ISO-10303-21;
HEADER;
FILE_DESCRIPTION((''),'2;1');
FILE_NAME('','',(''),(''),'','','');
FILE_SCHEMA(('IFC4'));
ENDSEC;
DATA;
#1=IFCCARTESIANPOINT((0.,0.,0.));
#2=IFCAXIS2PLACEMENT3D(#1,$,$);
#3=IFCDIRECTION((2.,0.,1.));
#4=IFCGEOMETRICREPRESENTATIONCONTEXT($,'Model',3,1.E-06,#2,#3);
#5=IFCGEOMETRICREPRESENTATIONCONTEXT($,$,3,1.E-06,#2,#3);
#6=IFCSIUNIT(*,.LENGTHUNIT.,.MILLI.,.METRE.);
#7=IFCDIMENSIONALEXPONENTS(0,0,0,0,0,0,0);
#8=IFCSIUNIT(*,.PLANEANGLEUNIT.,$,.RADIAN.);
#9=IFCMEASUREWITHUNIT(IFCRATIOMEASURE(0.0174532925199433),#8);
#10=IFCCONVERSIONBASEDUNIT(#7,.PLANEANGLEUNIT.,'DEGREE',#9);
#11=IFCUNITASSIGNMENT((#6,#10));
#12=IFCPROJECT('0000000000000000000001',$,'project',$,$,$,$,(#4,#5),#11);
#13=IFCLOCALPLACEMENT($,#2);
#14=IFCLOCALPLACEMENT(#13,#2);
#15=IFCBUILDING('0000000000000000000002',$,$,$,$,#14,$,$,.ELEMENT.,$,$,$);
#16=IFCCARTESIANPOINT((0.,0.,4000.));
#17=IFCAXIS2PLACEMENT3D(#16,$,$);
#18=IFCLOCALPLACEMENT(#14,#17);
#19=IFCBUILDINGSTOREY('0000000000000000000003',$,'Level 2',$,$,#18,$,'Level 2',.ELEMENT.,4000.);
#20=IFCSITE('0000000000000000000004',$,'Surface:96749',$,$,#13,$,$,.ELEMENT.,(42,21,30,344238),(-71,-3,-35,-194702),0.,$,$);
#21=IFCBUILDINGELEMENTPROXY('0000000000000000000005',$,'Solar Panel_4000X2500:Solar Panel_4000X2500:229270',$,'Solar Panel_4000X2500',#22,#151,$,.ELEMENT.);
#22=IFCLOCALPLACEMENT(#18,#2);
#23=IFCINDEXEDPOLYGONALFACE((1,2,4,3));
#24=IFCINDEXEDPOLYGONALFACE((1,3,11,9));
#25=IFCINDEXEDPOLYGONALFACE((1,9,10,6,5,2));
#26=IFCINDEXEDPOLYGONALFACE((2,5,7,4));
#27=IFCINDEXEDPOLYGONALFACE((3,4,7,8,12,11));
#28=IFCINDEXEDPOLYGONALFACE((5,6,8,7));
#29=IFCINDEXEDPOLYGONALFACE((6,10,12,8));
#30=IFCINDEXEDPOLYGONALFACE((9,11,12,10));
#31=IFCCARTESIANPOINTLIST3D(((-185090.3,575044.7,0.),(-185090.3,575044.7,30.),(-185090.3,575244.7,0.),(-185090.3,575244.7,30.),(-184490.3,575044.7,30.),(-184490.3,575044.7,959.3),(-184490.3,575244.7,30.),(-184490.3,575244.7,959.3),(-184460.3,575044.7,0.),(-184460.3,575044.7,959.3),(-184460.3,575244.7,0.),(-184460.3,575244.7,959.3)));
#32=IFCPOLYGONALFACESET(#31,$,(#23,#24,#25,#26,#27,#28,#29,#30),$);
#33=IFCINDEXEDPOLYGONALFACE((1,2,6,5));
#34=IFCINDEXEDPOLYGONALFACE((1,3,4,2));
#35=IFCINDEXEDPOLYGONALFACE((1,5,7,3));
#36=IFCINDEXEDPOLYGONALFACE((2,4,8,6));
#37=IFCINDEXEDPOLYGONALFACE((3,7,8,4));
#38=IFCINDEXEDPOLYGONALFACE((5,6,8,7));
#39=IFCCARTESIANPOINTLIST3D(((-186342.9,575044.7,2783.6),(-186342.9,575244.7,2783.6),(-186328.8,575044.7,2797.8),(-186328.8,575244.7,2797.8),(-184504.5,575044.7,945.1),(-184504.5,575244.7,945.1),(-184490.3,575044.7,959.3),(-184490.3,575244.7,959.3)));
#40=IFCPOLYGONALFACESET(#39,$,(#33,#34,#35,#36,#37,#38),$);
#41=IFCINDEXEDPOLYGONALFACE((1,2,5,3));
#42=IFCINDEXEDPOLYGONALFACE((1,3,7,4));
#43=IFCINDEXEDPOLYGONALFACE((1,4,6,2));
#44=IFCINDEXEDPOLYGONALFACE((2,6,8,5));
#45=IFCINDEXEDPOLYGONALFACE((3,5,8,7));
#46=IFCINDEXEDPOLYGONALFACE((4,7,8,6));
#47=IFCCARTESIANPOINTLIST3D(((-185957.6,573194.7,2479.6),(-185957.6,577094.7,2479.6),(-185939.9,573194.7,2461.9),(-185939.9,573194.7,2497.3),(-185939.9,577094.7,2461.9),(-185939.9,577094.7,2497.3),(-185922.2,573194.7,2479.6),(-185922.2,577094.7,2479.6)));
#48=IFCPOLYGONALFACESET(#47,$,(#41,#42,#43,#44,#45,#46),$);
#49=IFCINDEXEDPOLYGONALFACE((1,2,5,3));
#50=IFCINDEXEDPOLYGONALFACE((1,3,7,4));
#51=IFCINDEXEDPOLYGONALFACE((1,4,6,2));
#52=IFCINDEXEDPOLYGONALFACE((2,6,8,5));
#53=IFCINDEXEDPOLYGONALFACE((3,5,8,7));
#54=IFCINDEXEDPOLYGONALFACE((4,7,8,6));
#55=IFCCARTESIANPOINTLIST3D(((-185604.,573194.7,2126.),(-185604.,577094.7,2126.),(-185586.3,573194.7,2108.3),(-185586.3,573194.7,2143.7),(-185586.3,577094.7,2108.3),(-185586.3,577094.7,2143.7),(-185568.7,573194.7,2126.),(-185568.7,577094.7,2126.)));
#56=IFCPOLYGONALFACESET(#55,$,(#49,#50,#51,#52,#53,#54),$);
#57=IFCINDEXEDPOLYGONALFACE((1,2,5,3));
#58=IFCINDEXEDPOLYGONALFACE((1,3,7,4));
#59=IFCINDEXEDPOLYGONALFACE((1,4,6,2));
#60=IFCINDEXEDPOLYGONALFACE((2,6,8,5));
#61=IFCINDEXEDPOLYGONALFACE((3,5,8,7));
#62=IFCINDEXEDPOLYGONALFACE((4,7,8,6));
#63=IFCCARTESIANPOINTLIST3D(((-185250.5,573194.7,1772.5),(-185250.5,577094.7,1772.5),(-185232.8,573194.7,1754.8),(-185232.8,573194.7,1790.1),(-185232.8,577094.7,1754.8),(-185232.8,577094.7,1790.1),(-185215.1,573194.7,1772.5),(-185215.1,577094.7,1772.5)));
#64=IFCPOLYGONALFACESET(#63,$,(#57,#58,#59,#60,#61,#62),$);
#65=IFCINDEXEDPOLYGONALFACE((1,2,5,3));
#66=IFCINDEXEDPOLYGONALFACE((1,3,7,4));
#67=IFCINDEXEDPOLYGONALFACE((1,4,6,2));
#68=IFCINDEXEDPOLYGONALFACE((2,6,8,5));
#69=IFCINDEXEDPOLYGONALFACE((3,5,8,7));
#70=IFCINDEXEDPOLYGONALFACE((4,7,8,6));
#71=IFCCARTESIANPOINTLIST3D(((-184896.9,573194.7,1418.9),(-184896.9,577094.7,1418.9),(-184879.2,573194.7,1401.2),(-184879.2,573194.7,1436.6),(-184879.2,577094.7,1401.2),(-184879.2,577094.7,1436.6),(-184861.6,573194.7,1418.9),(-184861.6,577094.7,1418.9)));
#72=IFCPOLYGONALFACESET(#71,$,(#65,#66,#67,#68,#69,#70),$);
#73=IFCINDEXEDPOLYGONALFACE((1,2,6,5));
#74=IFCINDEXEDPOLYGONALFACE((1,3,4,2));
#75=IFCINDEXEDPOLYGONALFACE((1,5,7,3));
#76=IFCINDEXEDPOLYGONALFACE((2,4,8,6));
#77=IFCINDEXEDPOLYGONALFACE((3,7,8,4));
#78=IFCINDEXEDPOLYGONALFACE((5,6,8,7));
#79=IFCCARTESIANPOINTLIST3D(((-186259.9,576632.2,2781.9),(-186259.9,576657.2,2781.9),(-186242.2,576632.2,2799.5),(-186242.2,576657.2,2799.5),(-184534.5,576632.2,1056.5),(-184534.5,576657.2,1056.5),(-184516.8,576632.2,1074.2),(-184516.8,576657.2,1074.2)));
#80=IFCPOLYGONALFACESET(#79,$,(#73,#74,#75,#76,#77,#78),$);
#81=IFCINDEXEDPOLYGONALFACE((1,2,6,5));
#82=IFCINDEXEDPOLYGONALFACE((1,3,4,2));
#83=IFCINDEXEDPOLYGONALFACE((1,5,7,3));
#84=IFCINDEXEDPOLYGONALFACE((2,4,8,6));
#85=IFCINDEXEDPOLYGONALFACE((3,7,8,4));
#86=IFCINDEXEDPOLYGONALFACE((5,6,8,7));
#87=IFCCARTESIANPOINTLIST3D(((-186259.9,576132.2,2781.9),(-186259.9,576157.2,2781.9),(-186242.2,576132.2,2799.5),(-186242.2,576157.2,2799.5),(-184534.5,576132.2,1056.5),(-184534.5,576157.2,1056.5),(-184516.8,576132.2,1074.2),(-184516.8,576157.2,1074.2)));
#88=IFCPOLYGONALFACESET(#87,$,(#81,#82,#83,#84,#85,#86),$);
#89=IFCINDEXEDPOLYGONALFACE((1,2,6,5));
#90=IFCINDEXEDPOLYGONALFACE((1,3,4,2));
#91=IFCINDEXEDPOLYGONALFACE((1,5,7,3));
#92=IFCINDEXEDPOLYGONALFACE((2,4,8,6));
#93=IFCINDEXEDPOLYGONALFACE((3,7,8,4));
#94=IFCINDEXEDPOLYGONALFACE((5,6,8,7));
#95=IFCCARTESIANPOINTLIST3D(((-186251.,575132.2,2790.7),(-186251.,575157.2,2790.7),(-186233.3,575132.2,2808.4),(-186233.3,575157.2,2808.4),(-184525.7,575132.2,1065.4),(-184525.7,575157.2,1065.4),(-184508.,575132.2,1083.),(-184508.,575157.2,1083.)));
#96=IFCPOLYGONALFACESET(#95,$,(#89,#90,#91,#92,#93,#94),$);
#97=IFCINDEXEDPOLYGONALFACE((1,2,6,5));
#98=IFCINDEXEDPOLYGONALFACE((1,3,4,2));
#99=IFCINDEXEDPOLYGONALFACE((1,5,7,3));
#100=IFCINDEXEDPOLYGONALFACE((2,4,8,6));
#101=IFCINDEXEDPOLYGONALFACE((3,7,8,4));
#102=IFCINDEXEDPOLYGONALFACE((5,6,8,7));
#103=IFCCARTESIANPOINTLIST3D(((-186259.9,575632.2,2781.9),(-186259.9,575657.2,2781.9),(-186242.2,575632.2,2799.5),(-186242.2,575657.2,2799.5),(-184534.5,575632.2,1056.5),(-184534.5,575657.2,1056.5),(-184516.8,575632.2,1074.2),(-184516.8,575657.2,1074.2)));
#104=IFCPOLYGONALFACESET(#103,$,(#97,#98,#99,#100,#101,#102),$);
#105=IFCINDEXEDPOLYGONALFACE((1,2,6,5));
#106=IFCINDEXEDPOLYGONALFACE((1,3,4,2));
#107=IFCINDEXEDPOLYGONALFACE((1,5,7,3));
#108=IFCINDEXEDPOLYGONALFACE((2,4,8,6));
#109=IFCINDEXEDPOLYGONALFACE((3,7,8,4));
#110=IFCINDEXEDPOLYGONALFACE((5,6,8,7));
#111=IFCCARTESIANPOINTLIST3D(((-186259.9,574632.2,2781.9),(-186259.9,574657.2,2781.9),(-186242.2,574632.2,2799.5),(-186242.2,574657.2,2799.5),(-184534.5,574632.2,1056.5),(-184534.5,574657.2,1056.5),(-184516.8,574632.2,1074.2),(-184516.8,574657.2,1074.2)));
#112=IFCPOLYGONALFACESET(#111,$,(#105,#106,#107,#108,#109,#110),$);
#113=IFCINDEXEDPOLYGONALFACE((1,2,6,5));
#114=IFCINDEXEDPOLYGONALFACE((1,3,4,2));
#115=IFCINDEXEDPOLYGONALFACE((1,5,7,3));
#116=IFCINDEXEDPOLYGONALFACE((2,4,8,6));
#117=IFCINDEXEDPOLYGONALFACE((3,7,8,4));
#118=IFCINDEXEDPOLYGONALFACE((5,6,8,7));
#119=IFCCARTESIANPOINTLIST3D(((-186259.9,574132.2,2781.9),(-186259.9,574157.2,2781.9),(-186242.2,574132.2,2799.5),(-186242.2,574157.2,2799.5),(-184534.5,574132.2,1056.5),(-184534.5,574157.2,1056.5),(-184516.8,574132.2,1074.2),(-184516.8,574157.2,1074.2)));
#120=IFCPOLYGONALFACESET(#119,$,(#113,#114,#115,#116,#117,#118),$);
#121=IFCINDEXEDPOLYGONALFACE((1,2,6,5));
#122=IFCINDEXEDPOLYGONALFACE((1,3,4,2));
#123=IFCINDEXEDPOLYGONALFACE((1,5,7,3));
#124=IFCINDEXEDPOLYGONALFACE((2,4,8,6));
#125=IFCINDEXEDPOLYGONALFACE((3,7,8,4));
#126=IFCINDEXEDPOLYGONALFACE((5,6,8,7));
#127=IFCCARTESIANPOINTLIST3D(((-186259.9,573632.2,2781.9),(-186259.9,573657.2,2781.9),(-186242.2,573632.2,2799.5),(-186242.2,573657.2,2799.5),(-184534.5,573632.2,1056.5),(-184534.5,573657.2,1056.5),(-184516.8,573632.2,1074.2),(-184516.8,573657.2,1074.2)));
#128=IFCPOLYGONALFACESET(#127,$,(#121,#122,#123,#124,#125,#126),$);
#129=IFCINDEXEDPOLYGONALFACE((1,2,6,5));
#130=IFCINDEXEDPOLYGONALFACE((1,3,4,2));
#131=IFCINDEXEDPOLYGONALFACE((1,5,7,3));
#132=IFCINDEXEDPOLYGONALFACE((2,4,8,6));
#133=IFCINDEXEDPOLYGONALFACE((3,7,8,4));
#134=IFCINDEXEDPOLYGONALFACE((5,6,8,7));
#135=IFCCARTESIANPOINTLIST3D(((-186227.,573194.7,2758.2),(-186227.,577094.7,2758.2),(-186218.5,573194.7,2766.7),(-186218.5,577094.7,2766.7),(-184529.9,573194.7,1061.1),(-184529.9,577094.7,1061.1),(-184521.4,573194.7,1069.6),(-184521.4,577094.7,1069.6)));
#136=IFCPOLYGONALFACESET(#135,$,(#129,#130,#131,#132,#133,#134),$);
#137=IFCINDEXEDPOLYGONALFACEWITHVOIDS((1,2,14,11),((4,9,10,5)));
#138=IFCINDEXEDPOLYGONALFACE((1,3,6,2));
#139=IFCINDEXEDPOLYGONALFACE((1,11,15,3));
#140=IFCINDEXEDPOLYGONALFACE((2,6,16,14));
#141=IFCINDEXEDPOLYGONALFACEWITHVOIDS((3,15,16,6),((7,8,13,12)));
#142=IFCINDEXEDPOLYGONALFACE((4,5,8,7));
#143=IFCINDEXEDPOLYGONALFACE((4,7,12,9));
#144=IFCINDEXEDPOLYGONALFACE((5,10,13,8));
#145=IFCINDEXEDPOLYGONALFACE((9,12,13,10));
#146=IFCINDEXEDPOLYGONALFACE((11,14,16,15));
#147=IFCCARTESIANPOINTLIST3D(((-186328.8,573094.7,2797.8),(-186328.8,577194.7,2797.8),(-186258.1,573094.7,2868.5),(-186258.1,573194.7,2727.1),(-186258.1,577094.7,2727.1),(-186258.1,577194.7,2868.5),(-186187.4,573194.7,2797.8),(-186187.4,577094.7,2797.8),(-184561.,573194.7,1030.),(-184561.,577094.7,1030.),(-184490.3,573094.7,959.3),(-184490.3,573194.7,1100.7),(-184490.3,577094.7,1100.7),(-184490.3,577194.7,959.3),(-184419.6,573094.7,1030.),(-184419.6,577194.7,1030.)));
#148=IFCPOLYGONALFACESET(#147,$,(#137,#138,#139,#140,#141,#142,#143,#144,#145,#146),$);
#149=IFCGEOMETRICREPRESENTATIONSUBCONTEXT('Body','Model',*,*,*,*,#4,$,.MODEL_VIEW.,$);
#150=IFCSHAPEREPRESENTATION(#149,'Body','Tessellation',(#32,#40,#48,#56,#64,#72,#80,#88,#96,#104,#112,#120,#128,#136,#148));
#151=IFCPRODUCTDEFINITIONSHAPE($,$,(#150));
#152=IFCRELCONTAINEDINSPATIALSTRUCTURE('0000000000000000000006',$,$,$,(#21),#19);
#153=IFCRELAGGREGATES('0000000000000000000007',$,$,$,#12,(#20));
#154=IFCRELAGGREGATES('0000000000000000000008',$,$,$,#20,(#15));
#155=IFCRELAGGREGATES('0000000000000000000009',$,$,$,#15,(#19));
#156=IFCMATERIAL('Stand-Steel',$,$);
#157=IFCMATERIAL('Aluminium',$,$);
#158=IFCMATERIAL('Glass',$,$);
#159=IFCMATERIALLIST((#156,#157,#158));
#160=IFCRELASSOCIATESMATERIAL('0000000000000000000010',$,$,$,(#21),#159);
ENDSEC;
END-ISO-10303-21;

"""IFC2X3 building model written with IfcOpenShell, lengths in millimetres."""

from ifc_helpers import new_model, entity, si_unit, converted_unit, direction, frame, frame_2d, origin, origin_2d_with_axis, place, context, subcontext, project, spatial, polyline, rectangle, outline, extrude, source, transform, mapped, material, material_list, element, save


model = new_model("IFC2X3")

# Units and contexts
model_context = context("Model", 3, precision=1e-06, world=origin(), true_north=direction((2.0, 0.0, 1.0)))
context_of_model = context(None, 3, precision=1e-06, world=origin(), true_north=direction((2.0, 0.0, 1.0)))
body_context = subcontext(model_context, "Body", "Model", "MODEL_VIEW")
ifc_project = project(units=[si_unit("LENGTHUNIT", "METRE", prefix="MILLI"), converted_unit("PLANEANGLEUNIT", "DEGREE", entity("IfcRatioMeasure", 0.0174532925199433), si_unit("PLANEANGLEUNIT", "RADIAN"), dimensions=[0, 0, 0, 0, 0, 0, 0])], contexts=[model_context, context_of_model])

# Site, building, storey
site_placement = place(None, origin())
site = spatial("IfcSite", under=ifc_project, at=site_placement, Name="Surface:96749", CompositionType="ELEMENT", RefLatitude=(42, 21, 30, 344238), RefLongitude=(-71, -3, -35, -194702), RefElevation=0.0)
building_placement = place(site_placement, origin())
building = spatial("IfcBuilding", under=site, at=building_placement, CompositionType="ELEMENT")
storey_placement = place(building_placement, frame((0.0, 0.0, 4000.0)))
storey = spatial("IfcBuildingStorey", under=building, at=storey_placement, Name="Level 2", LongName="Level 2", CompositionType="ELEMENT", Elevation=4000.0)

# Building element proxy
ifc_material_1 = material(Name="Stand-Steel")
ifc_material_2 = material(Name="Aluminium")
ifc_material_3 = material(Name="Glass")
shared_shape = source(origin(), body_context, "Body", "SweptSolid", [
    extrude(outline(polyline([(-629.5, -220.0), (329.8, -220.0), (329.8, 410.0), (299.8, 410.0), (299.8, -190.0), (-629.5, -190.0), (-629.5, -220.0)])), frame((-190.0, -100.0, 299.8), z_axis=(0.0, 1.0, 0.0), x_axis=(0.0, 0.0, -1.0)), (0.0, 0.0, 1.0), 200.0),
    extrude(rectangle(XDim=20.0, YDim=200.0, at=frame_2d((0.0, 0.0), x_axis=(0.0, 1.0))), frame((-7.1, 0.0, 922.2), z_axis=(-0.707107, 0.0, 0.707107), x_axis=(0.0, 1.0, 0.0)), (0.0, 0.0, 1.0), 2600.0),
    extrude(rectangle(XDim=25.0, YDim=25.0, at=frame_2d((0.0, 0.0), x_axis=(1.0, 0.0))), frame((-1449.6, -1950.0, 2449.6), z_axis=(0.0, 1.0, 0.0), x_axis=(-0.707107, 0.0, -0.707107)), (0.0, 0.0, 1.0), 3900.0),
    extrude(rectangle(XDim=25.0, YDim=25.0, at=origin_2d_with_axis()), frame((-1096.0, -1950.0, 2096.0), z_axis=(0.0, 1.0, 0.0), x_axis=(-0.707107, 0.0, -0.707107)), (0.0, 0.0, 1.0), 3900.0),
    extrude(rectangle(XDim=25.0, YDim=25.0, at=origin_2d_with_axis()), frame((-742.5, -1950.0, 1742.5), z_axis=(0.0, 1.0, 0.0), x_axis=(-0.707107, 0.0, -0.707107)), (0.0, 0.0, 1.0), 3900.0),
    extrude(rectangle(XDim=25.0, YDim=25.0, at=frame_2d((0.0, 0.0), x_axis=(1.0, 0.0))), frame((-388.9, -1950.0, 1388.9), z_axis=(0.0, 1.0, 0.0), x_axis=(-0.707107, 0.0, -0.707107)), (0.0, 0.0, 1.0), 3900.0),
    extrude(rectangle(XDim=25.0, YDim=25.0, at=frame_2d((0.0, 0.0), x_axis=(0.0, 1.0))), frame((-35.4, 1500.0, 1035.4), z_axis=(-0.707107, 0.0, 0.707107), x_axis=(0.0, 1.0, 0.0)), (0.0, 0.0, 1.0), 2440.0),
    extrude(rectangle(XDim=25.0, YDim=25.0, at=frame_2d((0.0, 0.0), x_axis=(0.0, 1.0))), frame((-35.4, 1000.0, 1035.4), z_axis=(-0.707107, 0.0, 0.707107), x_axis=(0.0, 1.0, 0.0)), (0.0, 0.0, 1.0), 2440.0),
    extrude(rectangle(XDim=25.0, YDim=25.0, at=frame_2d((0.0, 0.0), x_axis=(0.0, 1.0))), frame((-26.5, 0.0, 1044.2), z_axis=(-0.707107, 0.0, 0.707107), x_axis=(0.0, -1.0, 0.0)), (0.0, 0.0, 1.0), 2440.0),
    extrude(rectangle(XDim=25.0, YDim=25.0, at=frame_2d((0.0, 0.0), x_axis=(0.0, 1.0))), frame((-35.4, 500.0, 1035.4), z_axis=(-0.707107, 0.0, 0.707107), x_axis=(0.0, 1.0, 0.0)), (0.0, 0.0, 1.0), 2440.0),
    extrude(rectangle(XDim=25.0, YDim=25.0, at=frame_2d((0.0, 0.0), x_axis=(0.0, 1.0))), frame((-35.4, -500.0, 1035.4), z_axis=(-0.707107, 0.0, 0.707107), x_axis=(0.0, 1.0, 0.0)), (0.0, 0.0, 1.0), 2440.0),
    extrude(rectangle(XDim=25.0, YDim=25.0, at=frame_2d((0.0, 0.0), x_axis=(0.0, 1.0))), frame((-35.4, -1000.0, 1035.4), z_axis=(-0.707107, 0.0, 0.707107), x_axis=(0.0, 1.0, 0.0)), (0.0, 0.0, 1.0), 2440.0),
    extrude(rectangle(XDim=25.0, YDim=25.0, at=frame_2d((0.0, 0.0), x_axis=(0.0, 1.0))), frame((-35.4, -1500.0, 1035.4), z_axis=(-0.707107, 0.0, 0.707107), x_axis=(0.0, 1.0, 0.0)), (0.0, 0.0, 1.0), 2440.0),
    extrude(rectangle(XDim=2400.0, YDim=12.0, at=frame_2d((0.0, 0.0), x_axis=(1.0, 0.0))), frame((-883.9, -1950.0, 1883.9), z_axis=(0.0, 1.0, 0.0), x_axis=(0.707107, 0.0, -0.707107)), (0.0, 0.0, 1.0), 3900.0),
    extrude(outline(polyline([(-2050.0, -1300.0), (2050.0, -1300.0), (2050.0, 1300.0), (-2050.0, 1300.0), (-2050.0, -1300.0)]), holes=[polyline([(1950.0, -1200.0), (-1950.0, -1200.0), (-1950.0, 1200.0), (1950.0, 1200.0), (1950.0, -1200.0)])]), frame((-919.2, 0.0, 1848.5), z_axis=(0.707107, 0.0, 0.707107), x_axis=(0.0, 1.0, 0.0)), (0.0, 0.0, 1.0), 100.0),
])
ifc_material_list_1 = material_list([ifc_material_1, ifc_material_2, ifc_material_3])
proxy_1_placement = place(storey_placement, frame((-184490.3, 575144.7, 30.0)))
element("IfcBuildingElementProxy", 1, at=proxy_1_placement, inside=storey, material=ifc_material_list_1, Name="Solar Panel_4000X2500:Solar Panel_4000X2500:229270", ObjectType="Solar Panel_4000X2500", CompositionType="ELEMENT", context=body_context, shape_type="MappedRepresentation", body=[
    mapped(shared_shape, transform((0.0, 0.0, 0.0), scale=1.0)),
])

save(model, "model.ifc")
